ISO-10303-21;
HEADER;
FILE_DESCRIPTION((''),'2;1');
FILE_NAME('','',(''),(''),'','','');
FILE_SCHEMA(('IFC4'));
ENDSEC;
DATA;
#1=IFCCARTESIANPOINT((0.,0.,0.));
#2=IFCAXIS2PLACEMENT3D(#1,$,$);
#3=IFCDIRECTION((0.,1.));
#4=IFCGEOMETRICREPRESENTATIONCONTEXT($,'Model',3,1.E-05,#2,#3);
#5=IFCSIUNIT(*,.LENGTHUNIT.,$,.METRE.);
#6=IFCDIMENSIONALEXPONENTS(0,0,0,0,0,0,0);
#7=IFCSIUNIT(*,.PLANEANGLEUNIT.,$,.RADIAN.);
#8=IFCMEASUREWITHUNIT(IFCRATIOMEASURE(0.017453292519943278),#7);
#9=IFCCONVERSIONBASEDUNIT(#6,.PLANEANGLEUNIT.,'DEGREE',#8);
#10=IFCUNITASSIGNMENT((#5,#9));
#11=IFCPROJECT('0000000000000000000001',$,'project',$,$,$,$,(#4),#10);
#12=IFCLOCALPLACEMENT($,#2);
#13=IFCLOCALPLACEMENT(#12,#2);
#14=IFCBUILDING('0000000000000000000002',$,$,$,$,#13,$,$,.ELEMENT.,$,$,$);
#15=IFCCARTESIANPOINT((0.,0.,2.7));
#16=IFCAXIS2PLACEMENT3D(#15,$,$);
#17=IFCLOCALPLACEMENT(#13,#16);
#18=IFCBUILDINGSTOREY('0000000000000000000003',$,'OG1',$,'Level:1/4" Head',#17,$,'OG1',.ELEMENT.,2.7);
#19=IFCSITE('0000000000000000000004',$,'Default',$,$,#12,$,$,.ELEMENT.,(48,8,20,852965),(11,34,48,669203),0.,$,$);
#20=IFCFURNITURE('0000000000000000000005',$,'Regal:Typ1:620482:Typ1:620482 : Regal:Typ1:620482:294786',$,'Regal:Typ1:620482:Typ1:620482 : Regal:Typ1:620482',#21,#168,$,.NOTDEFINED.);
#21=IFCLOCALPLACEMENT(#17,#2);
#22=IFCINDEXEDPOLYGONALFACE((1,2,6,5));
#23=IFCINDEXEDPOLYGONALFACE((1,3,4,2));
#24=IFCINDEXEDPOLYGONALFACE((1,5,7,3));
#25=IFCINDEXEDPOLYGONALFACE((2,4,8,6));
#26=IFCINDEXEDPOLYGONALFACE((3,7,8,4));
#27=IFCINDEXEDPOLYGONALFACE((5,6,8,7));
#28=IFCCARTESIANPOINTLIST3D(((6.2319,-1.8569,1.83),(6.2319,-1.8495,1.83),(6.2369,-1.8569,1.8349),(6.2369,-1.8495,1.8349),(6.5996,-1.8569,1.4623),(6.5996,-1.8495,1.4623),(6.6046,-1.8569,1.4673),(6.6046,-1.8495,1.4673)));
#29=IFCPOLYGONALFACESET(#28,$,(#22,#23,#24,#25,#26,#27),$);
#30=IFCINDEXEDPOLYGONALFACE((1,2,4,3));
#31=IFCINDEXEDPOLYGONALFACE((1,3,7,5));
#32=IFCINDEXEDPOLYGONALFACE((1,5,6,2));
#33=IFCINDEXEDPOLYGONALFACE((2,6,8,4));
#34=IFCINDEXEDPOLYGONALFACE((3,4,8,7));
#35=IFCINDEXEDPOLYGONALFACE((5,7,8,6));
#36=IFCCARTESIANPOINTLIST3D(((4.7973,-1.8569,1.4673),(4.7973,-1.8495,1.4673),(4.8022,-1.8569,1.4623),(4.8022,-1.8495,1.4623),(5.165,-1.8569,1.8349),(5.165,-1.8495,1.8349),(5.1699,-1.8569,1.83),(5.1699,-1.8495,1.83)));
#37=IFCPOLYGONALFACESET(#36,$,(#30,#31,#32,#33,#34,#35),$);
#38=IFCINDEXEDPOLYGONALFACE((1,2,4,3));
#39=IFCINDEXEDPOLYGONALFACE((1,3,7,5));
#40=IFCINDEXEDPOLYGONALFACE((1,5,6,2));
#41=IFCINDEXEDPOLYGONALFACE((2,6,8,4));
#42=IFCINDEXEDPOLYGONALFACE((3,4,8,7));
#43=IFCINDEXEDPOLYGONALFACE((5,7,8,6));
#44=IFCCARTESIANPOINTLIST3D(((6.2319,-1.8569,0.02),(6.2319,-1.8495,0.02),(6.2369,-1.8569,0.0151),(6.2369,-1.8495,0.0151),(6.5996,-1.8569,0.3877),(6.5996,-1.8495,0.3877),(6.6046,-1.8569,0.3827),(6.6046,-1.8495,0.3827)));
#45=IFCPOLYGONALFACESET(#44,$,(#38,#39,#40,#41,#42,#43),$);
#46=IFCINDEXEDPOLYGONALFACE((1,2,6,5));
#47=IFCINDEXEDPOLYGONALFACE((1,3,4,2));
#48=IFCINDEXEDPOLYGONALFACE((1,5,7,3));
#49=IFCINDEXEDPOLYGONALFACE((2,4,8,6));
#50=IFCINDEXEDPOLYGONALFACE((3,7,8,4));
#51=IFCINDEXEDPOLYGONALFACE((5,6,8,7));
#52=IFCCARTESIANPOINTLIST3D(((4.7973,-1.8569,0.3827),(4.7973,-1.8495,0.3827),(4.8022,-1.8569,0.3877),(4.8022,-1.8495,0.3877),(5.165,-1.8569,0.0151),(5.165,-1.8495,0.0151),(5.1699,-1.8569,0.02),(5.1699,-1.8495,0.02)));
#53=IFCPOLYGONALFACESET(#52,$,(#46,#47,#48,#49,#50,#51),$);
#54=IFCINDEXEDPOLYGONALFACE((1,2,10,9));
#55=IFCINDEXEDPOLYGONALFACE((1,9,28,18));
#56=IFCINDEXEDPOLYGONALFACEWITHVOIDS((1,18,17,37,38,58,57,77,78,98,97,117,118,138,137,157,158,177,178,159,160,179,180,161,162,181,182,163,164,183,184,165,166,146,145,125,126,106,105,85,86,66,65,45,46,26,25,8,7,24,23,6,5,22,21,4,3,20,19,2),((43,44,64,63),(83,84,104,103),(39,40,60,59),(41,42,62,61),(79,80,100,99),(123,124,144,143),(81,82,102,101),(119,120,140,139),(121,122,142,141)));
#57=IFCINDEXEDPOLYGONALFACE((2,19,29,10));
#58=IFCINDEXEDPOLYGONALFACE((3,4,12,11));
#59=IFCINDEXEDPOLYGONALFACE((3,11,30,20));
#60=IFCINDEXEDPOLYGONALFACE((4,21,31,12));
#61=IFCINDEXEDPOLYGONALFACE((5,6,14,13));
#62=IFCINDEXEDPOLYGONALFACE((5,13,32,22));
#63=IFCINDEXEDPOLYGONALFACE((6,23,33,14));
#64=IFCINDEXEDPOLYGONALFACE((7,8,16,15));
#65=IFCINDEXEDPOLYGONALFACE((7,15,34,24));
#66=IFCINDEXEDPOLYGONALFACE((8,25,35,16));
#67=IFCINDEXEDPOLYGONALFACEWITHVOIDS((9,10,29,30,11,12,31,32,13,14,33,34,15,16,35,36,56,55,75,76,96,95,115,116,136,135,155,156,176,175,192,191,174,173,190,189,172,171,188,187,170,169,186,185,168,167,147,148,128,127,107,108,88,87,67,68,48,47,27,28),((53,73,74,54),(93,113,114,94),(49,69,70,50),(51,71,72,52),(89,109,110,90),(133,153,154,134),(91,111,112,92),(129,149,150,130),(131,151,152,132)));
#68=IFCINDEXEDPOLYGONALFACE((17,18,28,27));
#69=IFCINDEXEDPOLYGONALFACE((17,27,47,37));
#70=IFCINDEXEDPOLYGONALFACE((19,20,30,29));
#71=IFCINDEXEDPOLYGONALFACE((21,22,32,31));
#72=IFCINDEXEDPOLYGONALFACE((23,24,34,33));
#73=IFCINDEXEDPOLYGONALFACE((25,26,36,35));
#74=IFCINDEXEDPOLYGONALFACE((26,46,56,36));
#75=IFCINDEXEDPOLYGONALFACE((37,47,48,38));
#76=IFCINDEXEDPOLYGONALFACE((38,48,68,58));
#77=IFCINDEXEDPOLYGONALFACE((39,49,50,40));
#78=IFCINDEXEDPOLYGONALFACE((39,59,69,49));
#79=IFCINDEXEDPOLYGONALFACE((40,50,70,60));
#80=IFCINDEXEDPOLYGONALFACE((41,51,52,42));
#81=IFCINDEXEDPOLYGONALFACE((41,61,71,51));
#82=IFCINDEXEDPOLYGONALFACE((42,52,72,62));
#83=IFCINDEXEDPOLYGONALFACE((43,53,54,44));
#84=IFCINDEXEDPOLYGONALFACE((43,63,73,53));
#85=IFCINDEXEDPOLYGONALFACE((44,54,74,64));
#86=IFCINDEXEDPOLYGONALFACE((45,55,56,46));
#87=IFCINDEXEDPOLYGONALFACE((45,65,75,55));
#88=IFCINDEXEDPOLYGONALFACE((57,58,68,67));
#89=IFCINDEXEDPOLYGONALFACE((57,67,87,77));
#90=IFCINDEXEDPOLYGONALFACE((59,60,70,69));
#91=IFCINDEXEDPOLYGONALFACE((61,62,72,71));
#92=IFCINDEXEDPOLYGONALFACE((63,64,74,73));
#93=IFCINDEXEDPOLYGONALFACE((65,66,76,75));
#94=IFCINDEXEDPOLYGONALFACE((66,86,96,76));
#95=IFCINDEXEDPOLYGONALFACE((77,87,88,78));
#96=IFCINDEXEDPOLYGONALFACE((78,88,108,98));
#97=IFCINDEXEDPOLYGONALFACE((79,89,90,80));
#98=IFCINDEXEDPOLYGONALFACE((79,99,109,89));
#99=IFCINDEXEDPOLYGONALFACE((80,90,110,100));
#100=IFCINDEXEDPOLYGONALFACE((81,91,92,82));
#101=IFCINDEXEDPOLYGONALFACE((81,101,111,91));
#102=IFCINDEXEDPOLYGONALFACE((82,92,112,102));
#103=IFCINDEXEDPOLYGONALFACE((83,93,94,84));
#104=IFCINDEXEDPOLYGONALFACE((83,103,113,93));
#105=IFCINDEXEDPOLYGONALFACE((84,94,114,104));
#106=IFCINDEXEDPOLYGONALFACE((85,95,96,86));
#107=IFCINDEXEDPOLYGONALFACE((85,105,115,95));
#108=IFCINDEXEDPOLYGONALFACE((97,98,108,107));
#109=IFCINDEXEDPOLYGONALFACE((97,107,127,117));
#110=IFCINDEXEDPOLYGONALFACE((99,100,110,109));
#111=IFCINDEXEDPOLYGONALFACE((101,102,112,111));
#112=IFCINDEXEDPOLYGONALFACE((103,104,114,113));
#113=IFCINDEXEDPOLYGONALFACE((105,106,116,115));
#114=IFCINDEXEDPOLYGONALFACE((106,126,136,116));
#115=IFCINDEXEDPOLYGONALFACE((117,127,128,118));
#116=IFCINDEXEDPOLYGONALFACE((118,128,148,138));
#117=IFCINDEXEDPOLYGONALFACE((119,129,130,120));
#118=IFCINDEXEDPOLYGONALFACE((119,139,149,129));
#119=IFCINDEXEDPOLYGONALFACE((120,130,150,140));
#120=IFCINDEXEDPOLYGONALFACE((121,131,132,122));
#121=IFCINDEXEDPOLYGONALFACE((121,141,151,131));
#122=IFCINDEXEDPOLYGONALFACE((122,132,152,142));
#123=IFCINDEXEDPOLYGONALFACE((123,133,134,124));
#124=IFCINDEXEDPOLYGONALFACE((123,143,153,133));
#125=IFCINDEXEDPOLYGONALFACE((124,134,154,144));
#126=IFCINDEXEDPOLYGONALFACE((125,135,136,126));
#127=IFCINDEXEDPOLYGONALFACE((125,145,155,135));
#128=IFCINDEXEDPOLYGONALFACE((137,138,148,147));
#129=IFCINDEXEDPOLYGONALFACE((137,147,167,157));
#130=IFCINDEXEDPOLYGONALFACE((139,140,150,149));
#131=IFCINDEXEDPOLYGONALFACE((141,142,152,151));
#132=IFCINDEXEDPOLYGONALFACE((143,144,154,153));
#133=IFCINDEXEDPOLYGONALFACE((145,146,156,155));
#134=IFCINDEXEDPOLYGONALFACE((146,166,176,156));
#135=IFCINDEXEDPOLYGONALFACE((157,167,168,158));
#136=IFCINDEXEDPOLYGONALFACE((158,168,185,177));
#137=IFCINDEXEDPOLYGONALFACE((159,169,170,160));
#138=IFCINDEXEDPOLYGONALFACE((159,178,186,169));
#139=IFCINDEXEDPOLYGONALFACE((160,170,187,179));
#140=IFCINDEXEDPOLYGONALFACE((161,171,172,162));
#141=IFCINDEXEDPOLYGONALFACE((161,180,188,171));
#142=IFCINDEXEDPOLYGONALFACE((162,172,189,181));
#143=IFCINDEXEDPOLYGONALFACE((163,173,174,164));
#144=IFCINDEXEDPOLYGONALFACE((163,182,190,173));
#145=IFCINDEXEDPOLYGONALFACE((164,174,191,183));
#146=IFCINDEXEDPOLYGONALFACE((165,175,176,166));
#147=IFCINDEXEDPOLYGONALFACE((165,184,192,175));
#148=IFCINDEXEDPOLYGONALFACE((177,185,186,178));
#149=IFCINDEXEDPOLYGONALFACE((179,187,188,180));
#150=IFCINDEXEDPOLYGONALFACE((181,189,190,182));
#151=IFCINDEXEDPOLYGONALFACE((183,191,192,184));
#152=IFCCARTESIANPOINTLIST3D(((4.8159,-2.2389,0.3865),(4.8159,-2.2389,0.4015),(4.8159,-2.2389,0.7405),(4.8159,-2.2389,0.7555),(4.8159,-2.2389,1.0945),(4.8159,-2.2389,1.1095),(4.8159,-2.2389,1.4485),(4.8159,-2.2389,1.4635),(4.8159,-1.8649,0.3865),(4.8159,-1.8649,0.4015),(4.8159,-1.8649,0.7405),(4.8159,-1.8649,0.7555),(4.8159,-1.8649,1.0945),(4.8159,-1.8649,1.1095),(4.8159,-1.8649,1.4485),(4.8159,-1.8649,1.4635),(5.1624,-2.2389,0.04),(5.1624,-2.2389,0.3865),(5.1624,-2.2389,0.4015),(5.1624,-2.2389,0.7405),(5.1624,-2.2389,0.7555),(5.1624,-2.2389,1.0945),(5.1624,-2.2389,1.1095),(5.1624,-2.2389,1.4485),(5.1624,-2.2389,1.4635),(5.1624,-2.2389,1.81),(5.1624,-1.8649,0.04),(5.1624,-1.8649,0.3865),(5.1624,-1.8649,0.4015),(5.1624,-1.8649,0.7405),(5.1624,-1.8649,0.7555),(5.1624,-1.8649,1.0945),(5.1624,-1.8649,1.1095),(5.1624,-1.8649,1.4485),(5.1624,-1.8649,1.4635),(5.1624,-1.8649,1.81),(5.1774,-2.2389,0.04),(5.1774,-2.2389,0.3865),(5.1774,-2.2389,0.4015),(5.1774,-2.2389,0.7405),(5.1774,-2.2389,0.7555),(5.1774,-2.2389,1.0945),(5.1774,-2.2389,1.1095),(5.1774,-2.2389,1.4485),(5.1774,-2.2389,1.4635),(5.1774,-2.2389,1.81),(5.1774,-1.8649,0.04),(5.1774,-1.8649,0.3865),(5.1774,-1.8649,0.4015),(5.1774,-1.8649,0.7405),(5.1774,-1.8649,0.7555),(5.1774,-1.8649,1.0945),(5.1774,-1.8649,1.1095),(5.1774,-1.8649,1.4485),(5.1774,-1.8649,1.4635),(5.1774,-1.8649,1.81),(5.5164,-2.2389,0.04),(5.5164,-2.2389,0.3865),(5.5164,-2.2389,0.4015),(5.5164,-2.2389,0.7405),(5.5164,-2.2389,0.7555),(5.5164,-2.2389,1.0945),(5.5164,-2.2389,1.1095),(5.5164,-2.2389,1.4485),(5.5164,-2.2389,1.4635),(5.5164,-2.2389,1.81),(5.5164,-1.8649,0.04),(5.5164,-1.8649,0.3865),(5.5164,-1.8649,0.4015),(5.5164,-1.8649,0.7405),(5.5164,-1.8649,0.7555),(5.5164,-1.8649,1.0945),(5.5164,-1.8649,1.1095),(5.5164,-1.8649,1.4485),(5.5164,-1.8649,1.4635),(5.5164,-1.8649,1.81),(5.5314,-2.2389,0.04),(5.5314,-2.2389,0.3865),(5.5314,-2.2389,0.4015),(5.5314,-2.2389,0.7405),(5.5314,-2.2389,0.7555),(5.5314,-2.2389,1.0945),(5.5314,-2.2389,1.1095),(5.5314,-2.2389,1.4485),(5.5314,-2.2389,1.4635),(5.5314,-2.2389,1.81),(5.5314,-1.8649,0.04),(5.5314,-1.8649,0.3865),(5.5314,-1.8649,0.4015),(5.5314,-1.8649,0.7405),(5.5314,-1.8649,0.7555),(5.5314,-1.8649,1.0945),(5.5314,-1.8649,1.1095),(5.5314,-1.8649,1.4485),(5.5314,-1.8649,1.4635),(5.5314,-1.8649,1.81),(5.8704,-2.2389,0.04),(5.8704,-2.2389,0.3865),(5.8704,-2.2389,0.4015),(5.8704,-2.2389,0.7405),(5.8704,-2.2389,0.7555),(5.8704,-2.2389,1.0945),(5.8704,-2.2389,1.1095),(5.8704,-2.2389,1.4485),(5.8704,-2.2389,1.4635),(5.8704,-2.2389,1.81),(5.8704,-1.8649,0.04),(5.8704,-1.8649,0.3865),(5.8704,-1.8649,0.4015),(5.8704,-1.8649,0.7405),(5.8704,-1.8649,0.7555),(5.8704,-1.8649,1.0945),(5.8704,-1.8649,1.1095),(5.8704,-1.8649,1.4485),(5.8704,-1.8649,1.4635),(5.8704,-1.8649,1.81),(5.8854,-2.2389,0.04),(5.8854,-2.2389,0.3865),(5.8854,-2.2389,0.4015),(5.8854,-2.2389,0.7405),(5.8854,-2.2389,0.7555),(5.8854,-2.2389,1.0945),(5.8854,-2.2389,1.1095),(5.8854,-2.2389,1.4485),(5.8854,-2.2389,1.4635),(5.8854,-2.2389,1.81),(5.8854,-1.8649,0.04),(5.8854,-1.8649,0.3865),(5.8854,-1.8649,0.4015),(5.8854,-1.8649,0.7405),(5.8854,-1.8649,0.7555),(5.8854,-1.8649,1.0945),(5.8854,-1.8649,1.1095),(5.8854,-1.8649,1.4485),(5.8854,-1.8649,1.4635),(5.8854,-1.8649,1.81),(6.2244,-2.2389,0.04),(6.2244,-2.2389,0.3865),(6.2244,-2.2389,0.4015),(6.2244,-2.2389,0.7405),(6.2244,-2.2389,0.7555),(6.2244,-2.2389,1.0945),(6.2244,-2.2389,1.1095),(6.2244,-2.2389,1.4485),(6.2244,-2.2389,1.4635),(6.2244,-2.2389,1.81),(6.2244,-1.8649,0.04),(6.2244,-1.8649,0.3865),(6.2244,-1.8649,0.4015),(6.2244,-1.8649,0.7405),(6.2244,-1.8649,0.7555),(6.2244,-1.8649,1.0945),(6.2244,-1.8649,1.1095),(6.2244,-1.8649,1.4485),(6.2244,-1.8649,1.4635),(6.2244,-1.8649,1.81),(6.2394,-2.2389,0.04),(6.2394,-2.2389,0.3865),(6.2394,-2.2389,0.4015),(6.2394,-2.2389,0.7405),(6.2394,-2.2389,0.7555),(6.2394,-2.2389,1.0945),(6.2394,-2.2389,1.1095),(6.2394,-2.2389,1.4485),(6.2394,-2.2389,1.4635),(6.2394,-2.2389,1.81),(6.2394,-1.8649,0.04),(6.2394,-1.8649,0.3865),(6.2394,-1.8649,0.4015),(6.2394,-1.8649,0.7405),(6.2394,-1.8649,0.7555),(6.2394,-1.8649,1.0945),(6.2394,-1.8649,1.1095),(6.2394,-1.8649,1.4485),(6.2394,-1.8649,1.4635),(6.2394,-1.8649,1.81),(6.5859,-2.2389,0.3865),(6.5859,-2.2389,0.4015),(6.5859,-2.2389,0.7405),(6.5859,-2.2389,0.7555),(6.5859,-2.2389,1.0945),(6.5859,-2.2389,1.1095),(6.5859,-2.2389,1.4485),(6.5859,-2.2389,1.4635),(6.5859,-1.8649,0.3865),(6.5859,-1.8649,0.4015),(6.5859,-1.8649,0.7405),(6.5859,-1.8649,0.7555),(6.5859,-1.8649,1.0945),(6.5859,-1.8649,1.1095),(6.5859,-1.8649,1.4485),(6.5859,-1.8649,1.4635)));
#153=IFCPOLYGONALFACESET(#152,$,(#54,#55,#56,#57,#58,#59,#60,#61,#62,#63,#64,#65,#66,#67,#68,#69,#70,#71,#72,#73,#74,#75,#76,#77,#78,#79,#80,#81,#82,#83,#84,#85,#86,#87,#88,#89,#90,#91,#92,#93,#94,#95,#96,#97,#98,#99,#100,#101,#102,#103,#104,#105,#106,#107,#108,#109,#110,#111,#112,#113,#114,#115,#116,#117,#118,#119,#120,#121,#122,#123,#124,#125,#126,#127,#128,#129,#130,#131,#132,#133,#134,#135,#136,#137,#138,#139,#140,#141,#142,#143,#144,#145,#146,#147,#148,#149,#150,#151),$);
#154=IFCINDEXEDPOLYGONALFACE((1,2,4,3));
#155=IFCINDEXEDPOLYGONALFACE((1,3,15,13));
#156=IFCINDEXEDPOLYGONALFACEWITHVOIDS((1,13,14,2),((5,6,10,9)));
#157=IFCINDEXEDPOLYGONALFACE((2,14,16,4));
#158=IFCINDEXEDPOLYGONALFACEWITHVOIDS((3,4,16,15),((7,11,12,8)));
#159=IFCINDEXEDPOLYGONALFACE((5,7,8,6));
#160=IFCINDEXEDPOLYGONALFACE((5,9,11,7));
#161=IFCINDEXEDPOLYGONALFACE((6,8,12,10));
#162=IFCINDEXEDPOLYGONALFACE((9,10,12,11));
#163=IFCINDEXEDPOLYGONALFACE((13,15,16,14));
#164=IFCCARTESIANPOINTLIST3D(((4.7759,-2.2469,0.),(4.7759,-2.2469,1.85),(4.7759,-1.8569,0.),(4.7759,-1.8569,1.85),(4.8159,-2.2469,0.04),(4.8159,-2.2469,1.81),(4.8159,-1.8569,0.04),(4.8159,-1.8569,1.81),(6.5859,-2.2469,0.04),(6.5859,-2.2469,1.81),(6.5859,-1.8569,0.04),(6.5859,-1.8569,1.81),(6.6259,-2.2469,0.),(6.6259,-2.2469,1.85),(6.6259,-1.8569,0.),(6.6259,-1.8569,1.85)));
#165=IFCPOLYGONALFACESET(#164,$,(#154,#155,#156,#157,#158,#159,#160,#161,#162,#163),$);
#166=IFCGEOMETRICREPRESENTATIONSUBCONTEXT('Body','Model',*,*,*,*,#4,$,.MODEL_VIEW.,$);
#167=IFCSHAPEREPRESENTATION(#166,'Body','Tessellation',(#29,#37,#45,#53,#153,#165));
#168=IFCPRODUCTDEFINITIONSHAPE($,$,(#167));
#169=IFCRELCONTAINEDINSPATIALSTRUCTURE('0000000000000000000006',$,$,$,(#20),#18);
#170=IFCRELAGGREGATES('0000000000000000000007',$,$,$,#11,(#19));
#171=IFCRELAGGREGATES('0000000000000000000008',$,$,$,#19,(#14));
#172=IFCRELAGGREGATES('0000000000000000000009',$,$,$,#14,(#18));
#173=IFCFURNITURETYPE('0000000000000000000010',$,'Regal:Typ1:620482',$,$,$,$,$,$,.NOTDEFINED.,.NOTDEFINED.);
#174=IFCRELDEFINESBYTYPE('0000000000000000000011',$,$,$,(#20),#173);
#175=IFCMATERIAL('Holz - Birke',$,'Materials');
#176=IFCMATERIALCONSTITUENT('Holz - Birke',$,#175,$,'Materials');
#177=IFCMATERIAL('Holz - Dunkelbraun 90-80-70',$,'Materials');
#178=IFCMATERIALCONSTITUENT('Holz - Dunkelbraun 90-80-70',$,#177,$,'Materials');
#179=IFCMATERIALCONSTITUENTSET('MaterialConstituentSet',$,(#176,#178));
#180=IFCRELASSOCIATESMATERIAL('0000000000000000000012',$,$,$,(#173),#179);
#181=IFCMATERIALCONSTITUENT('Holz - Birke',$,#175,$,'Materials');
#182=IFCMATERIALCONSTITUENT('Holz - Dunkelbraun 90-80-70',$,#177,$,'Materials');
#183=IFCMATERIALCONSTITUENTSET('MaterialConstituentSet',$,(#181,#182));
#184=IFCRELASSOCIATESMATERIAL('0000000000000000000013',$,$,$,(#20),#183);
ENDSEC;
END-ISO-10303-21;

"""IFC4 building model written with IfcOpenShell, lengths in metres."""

from ifc_helpers import new_model, entity, si_unit, converted_unit, direction, frame, origin, place, context, subcontext, project, spatial, indexed_curve, outline, extrude, source, transform, mapped, material, constituent, constituent_set, type_object, type_shapes, element, save


model = new_model("IFC4")

# Units and contexts
model_context = context("Model", 3, precision=1e-05, world=origin(), true_north=direction((0.0, 1.0)))
body_context = subcontext(model_context, "Body", "Model", "MODEL_VIEW")
ifc_project = project(units=[si_unit("LENGTHUNIT", "METRE"), converted_unit("PLANEANGLEUNIT", "DEGREE", entity("IfcRatioMeasure", 0.017453292519943278), si_unit("PLANEANGLEUNIT", "RADIAN"), dimensions=[0, 0, 0, 0, 0, 0, 0])], contexts=[model_context])

# Site, building, storey
site_placement = place(None, origin())
site = spatial("IfcSite", under=ifc_project, at=site_placement, Name="Default", CompositionType="ELEMENT", RefLatitude=(48, 8, 20, 852965), RefLongitude=(11, 34, 48, 669203), RefElevation=0.0)
building_placement = place(site_placement, origin())
building = spatial("IfcBuilding", under=site, at=building_placement, CompositionType="ELEMENT")
storey_placement = place(building_placement, frame((0.0, 0.0, 2.7)))
storey = spatial("IfcBuildingStorey", under=building, at=storey_placement, Name="OG1", ObjectType="Level:1/4\" Head", LongName="OG1", CompositionType="ELEMENT", Elevation=2.7)

# Shared definitions
ifc_material_1 = material(Name="Holz - Birke", Category="Materials")

# Furniture
ifc_material_2 = material(Name="Holz - Dunkelbraun 90-80-70", Category="Materials")
ifc_constituent_1 = constituent(ifc_material_1, Name="Holz - Birke", Category="Materials")
ifc_constituent_2 = constituent(ifc_material_2, Name="Holz - Dunkelbraun 90-80-70", Category="Materials")
ifc_constituent_set_1 = constituent_set(constituents=[ifc_constituent_1, ifc_constituent_2], Name="MaterialConstituentSet")
ifc_constituent_3 = constituent(ifc_material_1, Name="Holz - Birke", Category="Materials")
ifc_constituent_4 = constituent(ifc_material_2, Name="Holz - Dunkelbraun 90-80-70", Category="Materials")
ifc_constituent_set_2 = constituent_set(constituents=[ifc_constituent_3, ifc_constituent_4], Name="MaterialConstituentSet")
furniture_type_1 = type_object("IfcFurnitureType", Name="Regal:Typ1:620482", AssemblyPlace="NOTDEFINED", PredefinedType="NOTDEFINED", material=ifc_constituent_set_2)
shared_shape_1 = source(origin(), body_context, "Body", "SweptSolid", [
    extrude(outline(indexed_curve([(-0.0035, -0.0037), (0.0035, -0.0037), (0.0035, 0.0037), (-0.0035, 0.0037), (-0.0035, -0.0037)], self_intersect=False)), frame((6.6021, -1.8532, 4.1648), z_axis=(-0.707107, 0.0, 0.707107), x_axis=(-0.707107, 0.0, -0.707107)), (0.0, 0.0, 1.0), 0.52),
    extrude(outline(indexed_curve([(-0.0035, -0.0037), (0.0035, -0.0037), (0.0035, 0.0037), (-0.0035, 0.0037), (-0.0035, -0.0037)], self_intersect=False)), frame((4.7998, -1.8532, 4.1648), z_axis=(0.707107, 0.0, 0.707107), x_axis=(-0.707107, 0.0, 0.707107)), (0.0, 0.0, 1.0), 0.52),
    extrude(outline(indexed_curve([(-0.0035, -0.0037), (0.0035, -0.0037), (0.0035, 0.0037), (-0.0035, 0.0037), (-0.0035, -0.0037)], self_intersect=False)), frame((6.2344, -1.8532, 2.7175), z_axis=(0.707107, 0.0, 0.707107), x_axis=(-0.707107, 0.0, 0.707107)), (0.0, 0.0, 1.0), 0.52),
    extrude(outline(indexed_curve([(-0.0035, -0.0037), (0.0035, -0.0037), (0.0035, 0.0037), (-0.0035, 0.0037), (-0.0035, -0.0037)], self_intersect=False)), frame((5.1675, -1.8532, 2.7175), z_axis=(-0.707107, 0.0, 0.707107), x_axis=(-0.707107, 0.0, -0.707107)), (0.0, 0.0, 1.0), 0.52),
    extrude(outline(indexed_curve([(-0.5385, -0.885), (-0.5235, -0.885), (-0.5235, -0.5385), (-0.1845, -0.5385), (-0.1845, -0.885), (-0.1695, -0.885), (-0.1695, -0.5385), (0.1695, -0.5385), (0.1695, -0.885), (0.1845, -0.885), (0.1845, -0.5385), (0.5235, -0.5385), (0.5235, -0.885), (0.5385, -0.885), (0.5385, -0.5385), (0.885, -0.5385), (0.885, -0.5235), (0.5385, -0.5235), (0.5385, -0.1845), (0.885, -0.1845), (0.885, -0.1695), (0.5385, -0.1695), (0.5385, 0.1695), (0.885, 0.1695), (0.885, 0.1845), (0.5385, 0.1845), (0.5385, 0.5235), (0.885, 0.5235), (0.885, 0.5385), (0.5385, 0.5385), (0.5385, 0.885), (0.5235, 0.885), (0.5235, 0.5385), (0.1845, 0.5385), (0.1845, 0.885), (0.1695, 0.885), (0.1695, 0.5385), (-0.1695, 0.5385), (-0.1695, 0.885), (-0.1845, 0.885), (-0.1845, 0.5385), (-0.5235, 0.5385), (-0.5235, 0.885), (-0.5385, 0.885), (-0.5385, 0.5385), (-0.885, 0.5385), (-0.885, 0.5235), (-0.5385, 0.5235), (-0.5385, 0.1845), (-0.885, 0.1845), (-0.885, 0.1695), (-0.5385, 0.1695), (-0.5385, -0.1695), (-0.885, -0.1695), (-0.885, -0.1845), (-0.5385, -0.1845), (-0.5385, -0.5235), (-0.885, -0.5235), (-0.885, -0.5385), (-0.5385, -0.5385), (-0.5385, -0.885)], self_intersect=False), holes=[indexed_curve([(-0.5235, -0.5235), (-0.5235, -0.1845), (-0.1845, -0.1845), (-0.1845, -0.5235), (-0.5235, -0.5235)], self_intersect=False), indexed_curve([(0.1695, -0.1845), (0.1695, -0.5235), (-0.1695, -0.5235), (-0.1695, -0.1845), (0.1695, -0.1845)], self_intersect=False), indexed_curve([(0.5235, -0.1845), (0.5235, -0.5235), (0.1845, -0.5235), (0.1845, -0.1845), (0.5235, -0.1845)], self_intersect=False), indexed_curve([(0.5235, -0.1695), (0.1845, -0.1695), (0.1845, 0.1695), (0.5235, 0.1695), (0.5235, -0.1695)], self_intersect=False), indexed_curve([(0.1695, -0.1695), (-0.1695, -0.1695), (-0.1695, 0.1695), (0.1695, 0.1695), (0.1695, -0.1695)], self_intersect=False), indexed_curve([(-0.1845, -0.1695), (-0.5235, -0.1695), (-0.5235, 0.1695), (-0.1845, 0.1695), (-0.1845, -0.1695)], self_intersect=False), indexed_curve([(-0.1845, 0.5235), (-0.1845, 0.1845), (-0.5235, 0.1845), (-0.5235, 0.5235), (-0.1845, 0.5235)], self_intersect=False), indexed_curve([(0.1695, 0.5235), (0.1695, 0.1845), (-0.1695, 0.1845), (-0.1695, 0.5235), (0.1695, 0.5235)], self_intersect=False), indexed_curve([(0.5235, 0.5235), (0.5235, 0.1845), (0.1845, 0.1845), (0.1845, 0.5235), (0.5235, 0.5235)], self_intersect=False)]), frame((5.7009, -2.2389, 3.625), z_axis=(0.0, 1.0, 0.0), x_axis=(1.0, 0.0, 0.0)), (0.0, 0.0, 1.0), 0.374),
    extrude(outline(indexed_curve([(-0.925, -0.925), (0.925, -0.925), (0.925, 0.925), (-0.925, 0.925), (-0.925, -0.925)], self_intersect=False), holes=[indexed_curve([(0.885, 0.885), (0.885, -0.885), (-0.885, -0.885), (-0.885, 0.885), (0.885, 0.885)], self_intersect=False)]), frame((5.7009, -2.2469, 3.625), z_axis=(0.0, 1.0, 0.0), x_axis=(-1.0, 0.0, 0.0)), (0.0, 0.0, 1.0), 0.39),
])
type_shapes(furniture_type_1, [shared_shape_1])
furniture_1_placement = place(storey_placement, frame((0.0, 0.0, -2.7)))
element("IfcFurniture", 1, at=furniture_1_placement, inside=storey, type_object=furniture_type_1, material=ifc_constituent_set_1, Name="Regal:Typ1:620482:Typ1:620482 : Regal:Typ1:620482:294786", ObjectType="Regal:Typ1:620482:Typ1:620482 : Regal:Typ1:620482", PredefinedType="NOTDEFINED", context=body_context, shape_type="MappedRepresentation", body=[
    mapped(shared_shape_1, transform((0.0, 0.0, 0.0), scale=1.0)),
])

save(model, "model.ifc")
